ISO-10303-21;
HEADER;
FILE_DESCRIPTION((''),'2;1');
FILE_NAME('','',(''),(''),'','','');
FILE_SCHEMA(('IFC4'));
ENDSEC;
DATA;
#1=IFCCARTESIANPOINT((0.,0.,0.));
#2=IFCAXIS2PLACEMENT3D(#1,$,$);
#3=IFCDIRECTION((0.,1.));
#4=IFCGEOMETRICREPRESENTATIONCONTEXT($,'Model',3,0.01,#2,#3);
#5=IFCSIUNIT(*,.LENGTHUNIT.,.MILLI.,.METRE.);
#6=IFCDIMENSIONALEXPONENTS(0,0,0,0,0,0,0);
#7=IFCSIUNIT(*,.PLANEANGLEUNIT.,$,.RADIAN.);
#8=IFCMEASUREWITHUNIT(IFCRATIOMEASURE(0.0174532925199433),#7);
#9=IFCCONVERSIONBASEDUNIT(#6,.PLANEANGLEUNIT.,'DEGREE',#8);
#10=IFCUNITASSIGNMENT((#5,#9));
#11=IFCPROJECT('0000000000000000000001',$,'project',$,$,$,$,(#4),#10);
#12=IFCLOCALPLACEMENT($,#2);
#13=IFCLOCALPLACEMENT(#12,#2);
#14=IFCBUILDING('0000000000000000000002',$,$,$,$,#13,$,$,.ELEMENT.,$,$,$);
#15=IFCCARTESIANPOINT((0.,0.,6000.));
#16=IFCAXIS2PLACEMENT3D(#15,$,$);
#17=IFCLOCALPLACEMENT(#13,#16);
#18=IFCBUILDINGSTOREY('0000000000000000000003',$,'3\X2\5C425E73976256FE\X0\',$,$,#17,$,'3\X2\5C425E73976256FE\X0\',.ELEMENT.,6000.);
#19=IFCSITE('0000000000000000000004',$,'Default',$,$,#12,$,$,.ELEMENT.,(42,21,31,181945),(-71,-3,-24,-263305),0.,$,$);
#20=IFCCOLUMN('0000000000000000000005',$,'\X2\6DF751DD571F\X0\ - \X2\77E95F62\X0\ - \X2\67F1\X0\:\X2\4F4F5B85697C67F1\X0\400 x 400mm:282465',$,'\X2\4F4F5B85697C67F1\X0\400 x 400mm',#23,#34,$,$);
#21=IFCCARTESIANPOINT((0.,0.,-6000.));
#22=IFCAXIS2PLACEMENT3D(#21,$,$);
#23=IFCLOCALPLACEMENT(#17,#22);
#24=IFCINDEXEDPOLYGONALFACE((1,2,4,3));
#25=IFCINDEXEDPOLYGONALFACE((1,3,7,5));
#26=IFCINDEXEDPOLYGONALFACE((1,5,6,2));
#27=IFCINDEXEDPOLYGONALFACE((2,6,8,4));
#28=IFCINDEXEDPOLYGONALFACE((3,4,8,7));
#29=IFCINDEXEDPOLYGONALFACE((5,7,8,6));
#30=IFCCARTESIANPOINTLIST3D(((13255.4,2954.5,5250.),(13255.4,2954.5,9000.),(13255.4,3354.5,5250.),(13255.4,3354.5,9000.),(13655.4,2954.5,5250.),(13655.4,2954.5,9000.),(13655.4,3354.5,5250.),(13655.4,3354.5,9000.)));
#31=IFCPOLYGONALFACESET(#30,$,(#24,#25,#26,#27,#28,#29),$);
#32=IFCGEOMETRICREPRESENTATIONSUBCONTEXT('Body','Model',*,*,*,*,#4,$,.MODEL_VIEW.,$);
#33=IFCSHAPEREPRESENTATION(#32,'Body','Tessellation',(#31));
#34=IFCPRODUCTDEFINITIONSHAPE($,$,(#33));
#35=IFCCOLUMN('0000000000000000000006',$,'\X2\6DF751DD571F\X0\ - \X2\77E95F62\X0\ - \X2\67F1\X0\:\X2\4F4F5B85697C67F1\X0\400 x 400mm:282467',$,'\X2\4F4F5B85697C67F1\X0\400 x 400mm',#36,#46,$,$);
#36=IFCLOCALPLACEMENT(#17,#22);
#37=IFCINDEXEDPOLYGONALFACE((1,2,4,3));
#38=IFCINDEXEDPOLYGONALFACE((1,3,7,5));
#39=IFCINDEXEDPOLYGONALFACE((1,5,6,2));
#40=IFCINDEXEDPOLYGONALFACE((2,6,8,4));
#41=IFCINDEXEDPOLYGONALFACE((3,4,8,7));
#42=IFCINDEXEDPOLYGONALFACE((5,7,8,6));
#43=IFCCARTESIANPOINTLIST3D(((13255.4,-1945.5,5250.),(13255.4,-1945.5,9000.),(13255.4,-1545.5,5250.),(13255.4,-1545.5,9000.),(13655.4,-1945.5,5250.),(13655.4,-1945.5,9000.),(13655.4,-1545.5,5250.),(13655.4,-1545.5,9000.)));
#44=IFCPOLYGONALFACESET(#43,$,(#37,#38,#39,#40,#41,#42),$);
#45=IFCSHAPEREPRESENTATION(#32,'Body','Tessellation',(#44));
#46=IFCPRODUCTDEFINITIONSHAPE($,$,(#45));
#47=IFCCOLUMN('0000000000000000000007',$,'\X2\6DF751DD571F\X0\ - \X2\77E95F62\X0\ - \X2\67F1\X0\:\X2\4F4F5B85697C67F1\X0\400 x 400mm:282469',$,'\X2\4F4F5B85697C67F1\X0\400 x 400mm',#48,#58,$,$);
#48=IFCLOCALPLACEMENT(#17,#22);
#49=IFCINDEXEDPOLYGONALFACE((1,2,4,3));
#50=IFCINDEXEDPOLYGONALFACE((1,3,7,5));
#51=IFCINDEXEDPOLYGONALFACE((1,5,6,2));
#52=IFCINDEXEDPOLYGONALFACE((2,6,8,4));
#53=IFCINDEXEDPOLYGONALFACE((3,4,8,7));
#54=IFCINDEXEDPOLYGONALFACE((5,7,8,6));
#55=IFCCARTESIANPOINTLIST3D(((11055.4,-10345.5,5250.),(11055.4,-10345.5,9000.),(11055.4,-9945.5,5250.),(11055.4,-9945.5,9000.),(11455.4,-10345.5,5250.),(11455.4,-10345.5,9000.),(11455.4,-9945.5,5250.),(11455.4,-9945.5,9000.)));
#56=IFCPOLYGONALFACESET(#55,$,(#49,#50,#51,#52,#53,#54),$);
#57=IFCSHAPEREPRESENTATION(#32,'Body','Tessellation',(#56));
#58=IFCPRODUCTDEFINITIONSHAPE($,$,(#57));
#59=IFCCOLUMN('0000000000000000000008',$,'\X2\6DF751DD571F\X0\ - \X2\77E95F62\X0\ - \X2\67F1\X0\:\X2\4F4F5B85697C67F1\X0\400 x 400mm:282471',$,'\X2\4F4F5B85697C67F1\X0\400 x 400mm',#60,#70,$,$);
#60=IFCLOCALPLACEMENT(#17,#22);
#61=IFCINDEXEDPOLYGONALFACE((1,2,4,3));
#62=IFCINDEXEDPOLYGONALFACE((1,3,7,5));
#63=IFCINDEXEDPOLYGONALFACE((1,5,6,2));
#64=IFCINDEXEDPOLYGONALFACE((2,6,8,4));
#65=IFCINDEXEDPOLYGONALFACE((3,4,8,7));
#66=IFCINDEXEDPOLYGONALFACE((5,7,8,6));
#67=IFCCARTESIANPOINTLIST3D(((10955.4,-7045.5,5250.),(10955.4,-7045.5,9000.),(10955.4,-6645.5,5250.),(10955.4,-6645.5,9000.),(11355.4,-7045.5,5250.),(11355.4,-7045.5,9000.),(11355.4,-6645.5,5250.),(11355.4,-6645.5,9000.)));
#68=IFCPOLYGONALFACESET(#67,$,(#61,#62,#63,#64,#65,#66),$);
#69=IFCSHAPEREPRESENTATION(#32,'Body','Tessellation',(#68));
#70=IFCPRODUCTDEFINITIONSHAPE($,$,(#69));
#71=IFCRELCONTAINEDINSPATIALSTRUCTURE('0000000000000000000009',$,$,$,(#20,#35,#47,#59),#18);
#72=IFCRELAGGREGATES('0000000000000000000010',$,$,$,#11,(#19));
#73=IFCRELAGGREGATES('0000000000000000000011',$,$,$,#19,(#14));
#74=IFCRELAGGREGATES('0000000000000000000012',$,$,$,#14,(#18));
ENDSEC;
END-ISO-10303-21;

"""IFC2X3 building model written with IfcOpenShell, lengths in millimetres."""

from ifc_helpers import new_model, entity, si_unit, converted_unit, direction, frame, origin, origin_2d_with_axis, place, context, subcontext, project, spatial, rectangle, extrude, source, transform, mapped, element, save


model = new_model("IFC2X3")

# Units and contexts
model_context = context("Model", 3, precision=0.01, world=origin(), true_north=direction((0.0, 1.0)))
body_context = subcontext(model_context, "Body", "Model", "MODEL_VIEW")
ifc_project = project(units=[si_unit("LENGTHUNIT", "METRE", prefix="MILLI"), converted_unit("PLANEANGLEUNIT", "DEGREE", entity("IfcRatioMeasure", 0.0174532925199433), si_unit("PLANEANGLEUNIT", "RADIAN"), dimensions=[0, 0, 0, 0, 0, 0, 0])], contexts=[model_context])

# Site, building, storey
site_placement = place(None, origin())
site = spatial("IfcSite", under=ifc_project, at=site_placement, Name="Default", CompositionType="ELEMENT", RefLatitude=(42, 21, 31, 181945), RefLongitude=(-71, -3, -24, -263305), RefElevation=0.0)
building_placement = place(site_placement, origin())
building = spatial("IfcBuilding", under=site, at=building_placement, CompositionType="ELEMENT")
storey_placement = place(building_placement, frame((0.0, 0.0, 6000.0)))
storey = spatial("IfcBuildingStorey", under=building, at=storey_placement, Name="3层平面图", LongName="3层平面图", CompositionType="ELEMENT", Elevation=6000.0)

# Columns
shared_shape_1 = source(origin(), body_context, "Body", "SweptSolid", [
    extrude(rectangle(XDim=400.0, YDim=400.0, at=origin_2d_with_axis()), frame((13455.4, 3154.5, 5250.0), z_axis=(0.0, 0.0, 1.0), x_axis=(0.0, -1.0, 0.0)), (0.0, 0.0, 1.0), 3750.0),
])
column_1_placement = place(storey_placement, frame((0.0, 0.0, -6000.0)))
element("IfcColumn", 1, at=column_1_placement, inside=storey, Name="混凝土 - 矩形 - 柱:住宅楼柱400 x 400mm:282465", ObjectType="住宅楼柱400 x 400mm", context=body_context, shape_type="MappedRepresentation", body=[
    mapped(shared_shape_1, transform((0.0, 0.0, 0.0), scale=1.0)),
])
shared_shape_2 = source(origin(), body_context, "Body", "SweptSolid", [
    extrude(rectangle(XDim=400.0, YDim=400.0, at=origin_2d_with_axis()), frame((13455.4, -1745.5, 5250.0), z_axis=(0.0, 0.0, 1.0), x_axis=(0.0, -1.0, 0.0)), (0.0, 0.0, 1.0), 3750.0),
])
column_2_placement = place(storey_placement, frame((0.0, 0.0, -6000.0)))
element("IfcColumn", 2, at=column_2_placement, inside=storey, Name="混凝土 - 矩形 - 柱:住宅楼柱400 x 400mm:282467", ObjectType="住宅楼柱400 x 400mm", context=body_context, shape_type="MappedRepresentation", body=[
    mapped(shared_shape_2, transform((0.0, 0.0, 0.0), scale=1.0)),
])
shared_shape_3 = source(origin(), body_context, "Body", "SweptSolid", [
    extrude(rectangle(XDim=400.0, YDim=400.0, at=origin_2d_with_axis()), frame((11255.4, -10145.5, 5250.0), z_axis=(0.0, 0.0, 1.0), x_axis=(0.0, -1.0, 0.0)), (0.0, 0.0, 1.0), 3750.0),
])
column_3_placement = place(storey_placement, frame((0.0, 0.0, -6000.0)))
element("IfcColumn", 3, at=column_3_placement, inside=storey, Name="混凝土 - 矩形 - 柱:住宅楼柱400 x 400mm:282469", ObjectType="住宅楼柱400 x 400mm", context=body_context, shape_type="MappedRepresentation", body=[
    mapped(shared_shape_3, transform((0.0, 0.0, 0.0), scale=1.0)),
])
shared_shape_4 = source(origin(), body_context, "Body", "SweptSolid", [
    extrude(rectangle(XDim=400.0, YDim=400.0, at=origin_2d_with_axis()), frame((11155.4, -6845.5, 5250.0), z_axis=(0.0, 0.0, 1.0), x_axis=(0.0, -1.0, 0.0)), (0.0, 0.0, 1.0), 3750.0),
])
column_4_placement = place(storey_placement, frame((0.0, 0.0, -6000.0)))
element("IfcColumn", 4, at=column_4_placement, inside=storey, Name="混凝土 - 矩形 - 柱:住宅楼柱400 x 400mm:282471", ObjectType="住宅楼柱400 x 400mm", context=body_context, shape_type="MappedRepresentation", body=[
    mapped(shared_shape_4, transform((0.0, 0.0, 0.0), scale=1.0)),
])

save(model, "model.ifc")
